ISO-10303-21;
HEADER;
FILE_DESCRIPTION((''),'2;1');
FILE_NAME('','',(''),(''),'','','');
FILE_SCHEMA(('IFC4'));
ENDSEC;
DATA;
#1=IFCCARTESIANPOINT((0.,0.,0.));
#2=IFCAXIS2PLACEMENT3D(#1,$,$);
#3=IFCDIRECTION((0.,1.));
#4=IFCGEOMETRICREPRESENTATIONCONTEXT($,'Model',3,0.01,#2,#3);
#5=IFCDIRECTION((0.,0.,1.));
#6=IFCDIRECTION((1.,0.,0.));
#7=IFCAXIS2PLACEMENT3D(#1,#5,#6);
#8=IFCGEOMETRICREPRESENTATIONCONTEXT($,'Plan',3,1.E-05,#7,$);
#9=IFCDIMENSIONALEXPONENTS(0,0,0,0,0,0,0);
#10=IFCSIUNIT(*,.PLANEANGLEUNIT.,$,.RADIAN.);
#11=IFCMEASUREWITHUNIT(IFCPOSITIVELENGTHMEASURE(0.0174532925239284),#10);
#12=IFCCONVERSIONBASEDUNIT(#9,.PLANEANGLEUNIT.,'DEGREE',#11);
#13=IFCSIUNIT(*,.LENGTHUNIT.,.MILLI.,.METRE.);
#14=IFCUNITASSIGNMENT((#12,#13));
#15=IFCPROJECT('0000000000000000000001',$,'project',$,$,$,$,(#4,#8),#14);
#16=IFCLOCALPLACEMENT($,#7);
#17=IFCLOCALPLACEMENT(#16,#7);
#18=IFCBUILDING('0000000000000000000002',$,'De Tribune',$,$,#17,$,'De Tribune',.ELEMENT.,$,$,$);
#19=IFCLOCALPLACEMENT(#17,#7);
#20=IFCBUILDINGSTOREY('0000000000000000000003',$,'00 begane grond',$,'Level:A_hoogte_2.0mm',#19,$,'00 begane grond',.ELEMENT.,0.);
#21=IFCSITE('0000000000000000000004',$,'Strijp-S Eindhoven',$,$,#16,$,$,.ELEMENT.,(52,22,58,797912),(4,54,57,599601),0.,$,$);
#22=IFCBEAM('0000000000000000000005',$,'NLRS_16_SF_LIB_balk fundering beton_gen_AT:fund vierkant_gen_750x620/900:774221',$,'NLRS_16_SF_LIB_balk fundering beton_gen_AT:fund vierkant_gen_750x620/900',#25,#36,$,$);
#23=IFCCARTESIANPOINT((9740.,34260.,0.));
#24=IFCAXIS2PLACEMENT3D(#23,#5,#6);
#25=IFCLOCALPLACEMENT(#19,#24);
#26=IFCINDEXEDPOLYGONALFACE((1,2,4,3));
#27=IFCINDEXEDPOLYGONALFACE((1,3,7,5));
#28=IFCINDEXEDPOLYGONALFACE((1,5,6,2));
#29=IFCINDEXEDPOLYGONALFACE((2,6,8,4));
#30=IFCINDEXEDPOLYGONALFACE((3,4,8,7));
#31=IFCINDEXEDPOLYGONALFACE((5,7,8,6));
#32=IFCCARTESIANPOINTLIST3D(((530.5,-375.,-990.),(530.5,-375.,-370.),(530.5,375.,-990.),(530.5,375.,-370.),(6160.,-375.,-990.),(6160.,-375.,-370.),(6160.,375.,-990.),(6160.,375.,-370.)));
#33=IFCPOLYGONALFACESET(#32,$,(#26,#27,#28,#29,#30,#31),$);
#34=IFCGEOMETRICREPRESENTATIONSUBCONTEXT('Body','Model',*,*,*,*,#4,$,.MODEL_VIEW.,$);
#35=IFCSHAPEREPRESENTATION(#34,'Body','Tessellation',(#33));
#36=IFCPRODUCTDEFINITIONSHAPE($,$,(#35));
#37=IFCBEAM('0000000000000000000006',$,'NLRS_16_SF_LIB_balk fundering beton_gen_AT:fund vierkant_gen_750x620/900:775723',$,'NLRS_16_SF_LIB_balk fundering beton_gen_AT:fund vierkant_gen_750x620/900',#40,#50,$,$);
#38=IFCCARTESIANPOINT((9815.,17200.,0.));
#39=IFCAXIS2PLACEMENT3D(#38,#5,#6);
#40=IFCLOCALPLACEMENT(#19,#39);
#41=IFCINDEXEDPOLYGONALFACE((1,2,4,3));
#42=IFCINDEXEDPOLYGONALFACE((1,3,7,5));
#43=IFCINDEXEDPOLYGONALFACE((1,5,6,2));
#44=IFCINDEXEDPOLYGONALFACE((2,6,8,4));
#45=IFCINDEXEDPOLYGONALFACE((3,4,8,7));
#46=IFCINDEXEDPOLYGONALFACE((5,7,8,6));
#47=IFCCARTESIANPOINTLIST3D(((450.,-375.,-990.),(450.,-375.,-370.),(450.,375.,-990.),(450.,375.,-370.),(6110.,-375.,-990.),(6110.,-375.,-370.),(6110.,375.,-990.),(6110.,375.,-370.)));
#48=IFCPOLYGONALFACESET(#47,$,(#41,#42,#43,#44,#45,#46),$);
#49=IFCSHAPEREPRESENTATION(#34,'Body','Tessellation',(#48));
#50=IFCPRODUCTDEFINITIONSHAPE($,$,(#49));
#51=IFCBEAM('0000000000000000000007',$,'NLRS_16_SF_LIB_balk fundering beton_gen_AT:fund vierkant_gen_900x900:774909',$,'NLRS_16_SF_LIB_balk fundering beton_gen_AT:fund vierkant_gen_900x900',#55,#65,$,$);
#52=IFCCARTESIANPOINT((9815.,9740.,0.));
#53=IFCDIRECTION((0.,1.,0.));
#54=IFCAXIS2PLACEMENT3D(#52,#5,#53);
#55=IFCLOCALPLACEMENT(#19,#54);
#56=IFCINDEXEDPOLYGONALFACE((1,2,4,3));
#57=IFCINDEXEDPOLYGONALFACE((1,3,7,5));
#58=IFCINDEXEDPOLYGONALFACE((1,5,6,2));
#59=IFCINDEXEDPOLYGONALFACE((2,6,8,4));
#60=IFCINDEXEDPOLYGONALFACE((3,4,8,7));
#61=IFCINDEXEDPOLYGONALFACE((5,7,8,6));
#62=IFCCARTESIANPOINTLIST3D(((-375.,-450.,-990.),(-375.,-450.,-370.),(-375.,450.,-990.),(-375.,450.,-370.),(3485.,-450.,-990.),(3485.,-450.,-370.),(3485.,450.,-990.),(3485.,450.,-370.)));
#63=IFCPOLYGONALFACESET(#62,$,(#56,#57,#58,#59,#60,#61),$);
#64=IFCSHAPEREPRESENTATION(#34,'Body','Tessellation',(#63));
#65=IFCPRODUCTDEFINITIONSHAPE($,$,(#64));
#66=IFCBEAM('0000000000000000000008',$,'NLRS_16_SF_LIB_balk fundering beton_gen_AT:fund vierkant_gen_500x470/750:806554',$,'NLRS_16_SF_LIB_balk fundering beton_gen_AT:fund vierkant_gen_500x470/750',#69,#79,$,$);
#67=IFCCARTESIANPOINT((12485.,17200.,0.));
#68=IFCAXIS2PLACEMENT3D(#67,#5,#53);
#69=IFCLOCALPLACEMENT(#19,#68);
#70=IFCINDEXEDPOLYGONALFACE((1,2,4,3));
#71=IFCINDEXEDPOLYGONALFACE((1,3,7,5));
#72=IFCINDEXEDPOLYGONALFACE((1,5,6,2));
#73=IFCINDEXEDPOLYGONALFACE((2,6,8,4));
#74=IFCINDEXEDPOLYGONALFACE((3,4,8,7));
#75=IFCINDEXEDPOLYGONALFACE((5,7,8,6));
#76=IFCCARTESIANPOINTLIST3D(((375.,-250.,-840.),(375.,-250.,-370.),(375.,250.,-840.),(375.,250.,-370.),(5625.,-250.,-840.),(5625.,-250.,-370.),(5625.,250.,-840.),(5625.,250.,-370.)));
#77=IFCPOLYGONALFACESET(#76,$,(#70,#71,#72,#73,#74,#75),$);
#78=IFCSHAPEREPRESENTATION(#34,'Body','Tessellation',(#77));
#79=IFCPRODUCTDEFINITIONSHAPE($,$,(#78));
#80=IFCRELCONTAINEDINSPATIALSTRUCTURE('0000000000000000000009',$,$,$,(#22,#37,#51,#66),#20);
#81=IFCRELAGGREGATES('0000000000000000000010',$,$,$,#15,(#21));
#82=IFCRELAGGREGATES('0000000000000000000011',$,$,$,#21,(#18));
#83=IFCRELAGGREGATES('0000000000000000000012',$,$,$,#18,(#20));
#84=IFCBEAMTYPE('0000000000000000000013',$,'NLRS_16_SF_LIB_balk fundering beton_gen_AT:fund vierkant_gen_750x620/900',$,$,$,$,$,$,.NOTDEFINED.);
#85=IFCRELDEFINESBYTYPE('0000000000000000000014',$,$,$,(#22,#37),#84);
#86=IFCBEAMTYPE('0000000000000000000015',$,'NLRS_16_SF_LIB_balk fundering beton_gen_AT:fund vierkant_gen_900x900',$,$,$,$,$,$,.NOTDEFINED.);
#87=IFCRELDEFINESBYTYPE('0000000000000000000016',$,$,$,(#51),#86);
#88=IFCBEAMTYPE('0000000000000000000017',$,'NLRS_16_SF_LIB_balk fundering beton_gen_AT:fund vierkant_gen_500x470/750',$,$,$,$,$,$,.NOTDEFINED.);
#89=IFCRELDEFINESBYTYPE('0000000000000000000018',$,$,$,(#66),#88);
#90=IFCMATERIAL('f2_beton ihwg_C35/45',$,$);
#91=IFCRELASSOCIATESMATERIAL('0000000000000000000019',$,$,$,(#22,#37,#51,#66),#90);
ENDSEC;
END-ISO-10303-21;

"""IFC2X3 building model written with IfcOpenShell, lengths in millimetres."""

from ifc_helpers import new_model, entity, si_unit, converted_unit, direction, frame, frame_2d, origin, origin_with_axes, place, context, subcontext, project, spatial, rectangle, extrude, material, type_object, element, save


model = new_model("IFC2X3")

# Units and contexts
model_context = context("Model", 3, precision=0.01, world=origin(), true_north=direction((0.0, 1.0)))
plan_context = context("Plan", 3, precision=1e-05, world=origin_with_axes())
body_context = subcontext(model_context, "Body", "Model", "MODEL_VIEW")
ifc_project = project(units=[converted_unit("PLANEANGLEUNIT", "DEGREE", entity("IfcPositiveLengthMeasure", 0.0174532925239284), si_unit("PLANEANGLEUNIT", "RADIAN"), dimensions=[0, 0, 0, 0, 0, 0, 0]), si_unit("LENGTHUNIT", "METRE", prefix="MILLI")], contexts=[model_context, plan_context])

# Site, building, storey
site_placement = place(None, origin_with_axes())
site = spatial("IfcSite", under=ifc_project, at=site_placement, Name="Strijp-S Eindhoven", CompositionType="ELEMENT", RefLatitude=(52, 22, 58, 797912), RefLongitude=(4, 54, 57, 599601), RefElevation=0.0)
building_placement = place(site_placement, origin_with_axes())
building = spatial("IfcBuilding", under=site, at=building_placement, Name="De Tribune", LongName="De Tribune", CompositionType="ELEMENT")
storey_placement = place(building_placement, origin_with_axes())
storey = spatial("IfcBuildingStorey", under=building, at=storey_placement, Name="00 begane grond", ObjectType="Level:A_hoogte_2.0mm", LongName="00 begane grond", CompositionType="ELEMENT", Elevation=0.0)

# Shared definitions
ifc_material_1 = material(Name="f2_beton ihwg_C35/45")

# Beams
beam_type_1 = type_object("IfcBeamType", Name="NLRS_16_SF_LIB_balk fundering beton_gen_AT:fund vierkant_gen_750x620/900", PredefinedType="NOTDEFINED")
beam_1_placement = place(storey_placement, frame((9740.0, 34260.0, 0.0), z_axis=(0.0, 0.0, 1.0), x_axis=(1.0, 0.0, 0.0)))
element("IfcBeam", 1, at=beam_1_placement, inside=storey, type_object=beam_type_1, material=ifc_material_1, Name="NLRS_16_SF_LIB_balk fundering beton_gen_AT:fund vierkant_gen_750x620/900:774221", ObjectType="NLRS_16_SF_LIB_balk fundering beton_gen_AT:fund vierkant_gen_750x620/900", context=body_context, shape_type="SweptSolid", body=[
    extrude(rectangle(XDim=620.0, YDim=750.0, at=frame_2d((0.0, 0.0), x_axis=(1.0, 0.0))), frame((530.5, 0.0, -680.0), z_axis=(1.0, 0.0, 0.0), x_axis=(0.0, 0.0, -1.0)), (0.0, 0.0, 1.0), 5629.5),
])
beam_2_placement = place(storey_placement, frame((9815.0, 17200.0, 0.0), z_axis=(0.0, 0.0, 1.0), x_axis=(1.0, 0.0, 0.0)))
element("IfcBeam", 2, at=beam_2_placement, inside=storey, type_object=beam_type_1, material=ifc_material_1, Name="NLRS_16_SF_LIB_balk fundering beton_gen_AT:fund vierkant_gen_750x620/900:775723", ObjectType="NLRS_16_SF_LIB_balk fundering beton_gen_AT:fund vierkant_gen_750x620/900", context=body_context, shape_type="SweptSolid", body=[
    extrude(rectangle(XDim=620.0, YDim=750.0, at=frame_2d((0.0, 0.0), x_axis=(1.0, 0.0))), frame((450.0, 0.0, -680.0), z_axis=(1.0, 0.0, 0.0), x_axis=(0.0, 0.0, -1.0)), (0.0, 0.0, 1.0), 5660.0),
])
beam_type_2 = type_object("IfcBeamType", Name="NLRS_16_SF_LIB_balk fundering beton_gen_AT:fund vierkant_gen_900x900", PredefinedType="NOTDEFINED")
beam_3_placement = place(storey_placement, frame((9815.0, 9740.0, 0.0), z_axis=(0.0, 0.0, 1.0), x_axis=(0.0, 1.0, 0.0)))
element("IfcBeam", 3, at=beam_3_placement, inside=storey, type_object=beam_type_2, material=ifc_material_1, Name="NLRS_16_SF_LIB_balk fundering beton_gen_AT:fund vierkant_gen_900x900:774909", ObjectType="NLRS_16_SF_LIB_balk fundering beton_gen_AT:fund vierkant_gen_900x900", context=body_context, shape_type="SweptSolid", body=[
    extrude(rectangle(XDim=620.0, YDim=900.0, at=frame_2d((0.0, 0.0), x_axis=(1.0, 0.0))), frame((-375.0, 0.0, -680.0), z_axis=(1.0, 0.0, 0.0), x_axis=(0.0, 0.0, -1.0)), (0.0, 0.0, 1.0), 3860.0),
])
beam_type_3 = type_object("IfcBeamType", Name="NLRS_16_SF_LIB_balk fundering beton_gen_AT:fund vierkant_gen_500x470/750", PredefinedType="NOTDEFINED")
beam_4_placement = place(storey_placement, frame((12485.0, 17200.0, 0.0), z_axis=(0.0, 0.0, 1.0), x_axis=(0.0, 1.0, 0.0)))
element("IfcBeam", 4, at=beam_4_placement, inside=storey, type_object=beam_type_3, material=ifc_material_1, Name="NLRS_16_SF_LIB_balk fundering beton_gen_AT:fund vierkant_gen_500x470/750:806554", ObjectType="NLRS_16_SF_LIB_balk fundering beton_gen_AT:fund vierkant_gen_500x470/750", context=body_context, shape_type="SweptSolid", body=[
    extrude(rectangle(XDim=470.0, YDim=500.0, at=frame_2d((0.0, 0.0), x_axis=(1.0, 0.0))), frame((375.0, 0.0, -605.0), z_axis=(1.0, 0.0, 0.0), x_axis=(0.0, 0.0, -1.0)), (0.0, 0.0, 1.0), 5250.0),
])

save(model, "model.ifc")
